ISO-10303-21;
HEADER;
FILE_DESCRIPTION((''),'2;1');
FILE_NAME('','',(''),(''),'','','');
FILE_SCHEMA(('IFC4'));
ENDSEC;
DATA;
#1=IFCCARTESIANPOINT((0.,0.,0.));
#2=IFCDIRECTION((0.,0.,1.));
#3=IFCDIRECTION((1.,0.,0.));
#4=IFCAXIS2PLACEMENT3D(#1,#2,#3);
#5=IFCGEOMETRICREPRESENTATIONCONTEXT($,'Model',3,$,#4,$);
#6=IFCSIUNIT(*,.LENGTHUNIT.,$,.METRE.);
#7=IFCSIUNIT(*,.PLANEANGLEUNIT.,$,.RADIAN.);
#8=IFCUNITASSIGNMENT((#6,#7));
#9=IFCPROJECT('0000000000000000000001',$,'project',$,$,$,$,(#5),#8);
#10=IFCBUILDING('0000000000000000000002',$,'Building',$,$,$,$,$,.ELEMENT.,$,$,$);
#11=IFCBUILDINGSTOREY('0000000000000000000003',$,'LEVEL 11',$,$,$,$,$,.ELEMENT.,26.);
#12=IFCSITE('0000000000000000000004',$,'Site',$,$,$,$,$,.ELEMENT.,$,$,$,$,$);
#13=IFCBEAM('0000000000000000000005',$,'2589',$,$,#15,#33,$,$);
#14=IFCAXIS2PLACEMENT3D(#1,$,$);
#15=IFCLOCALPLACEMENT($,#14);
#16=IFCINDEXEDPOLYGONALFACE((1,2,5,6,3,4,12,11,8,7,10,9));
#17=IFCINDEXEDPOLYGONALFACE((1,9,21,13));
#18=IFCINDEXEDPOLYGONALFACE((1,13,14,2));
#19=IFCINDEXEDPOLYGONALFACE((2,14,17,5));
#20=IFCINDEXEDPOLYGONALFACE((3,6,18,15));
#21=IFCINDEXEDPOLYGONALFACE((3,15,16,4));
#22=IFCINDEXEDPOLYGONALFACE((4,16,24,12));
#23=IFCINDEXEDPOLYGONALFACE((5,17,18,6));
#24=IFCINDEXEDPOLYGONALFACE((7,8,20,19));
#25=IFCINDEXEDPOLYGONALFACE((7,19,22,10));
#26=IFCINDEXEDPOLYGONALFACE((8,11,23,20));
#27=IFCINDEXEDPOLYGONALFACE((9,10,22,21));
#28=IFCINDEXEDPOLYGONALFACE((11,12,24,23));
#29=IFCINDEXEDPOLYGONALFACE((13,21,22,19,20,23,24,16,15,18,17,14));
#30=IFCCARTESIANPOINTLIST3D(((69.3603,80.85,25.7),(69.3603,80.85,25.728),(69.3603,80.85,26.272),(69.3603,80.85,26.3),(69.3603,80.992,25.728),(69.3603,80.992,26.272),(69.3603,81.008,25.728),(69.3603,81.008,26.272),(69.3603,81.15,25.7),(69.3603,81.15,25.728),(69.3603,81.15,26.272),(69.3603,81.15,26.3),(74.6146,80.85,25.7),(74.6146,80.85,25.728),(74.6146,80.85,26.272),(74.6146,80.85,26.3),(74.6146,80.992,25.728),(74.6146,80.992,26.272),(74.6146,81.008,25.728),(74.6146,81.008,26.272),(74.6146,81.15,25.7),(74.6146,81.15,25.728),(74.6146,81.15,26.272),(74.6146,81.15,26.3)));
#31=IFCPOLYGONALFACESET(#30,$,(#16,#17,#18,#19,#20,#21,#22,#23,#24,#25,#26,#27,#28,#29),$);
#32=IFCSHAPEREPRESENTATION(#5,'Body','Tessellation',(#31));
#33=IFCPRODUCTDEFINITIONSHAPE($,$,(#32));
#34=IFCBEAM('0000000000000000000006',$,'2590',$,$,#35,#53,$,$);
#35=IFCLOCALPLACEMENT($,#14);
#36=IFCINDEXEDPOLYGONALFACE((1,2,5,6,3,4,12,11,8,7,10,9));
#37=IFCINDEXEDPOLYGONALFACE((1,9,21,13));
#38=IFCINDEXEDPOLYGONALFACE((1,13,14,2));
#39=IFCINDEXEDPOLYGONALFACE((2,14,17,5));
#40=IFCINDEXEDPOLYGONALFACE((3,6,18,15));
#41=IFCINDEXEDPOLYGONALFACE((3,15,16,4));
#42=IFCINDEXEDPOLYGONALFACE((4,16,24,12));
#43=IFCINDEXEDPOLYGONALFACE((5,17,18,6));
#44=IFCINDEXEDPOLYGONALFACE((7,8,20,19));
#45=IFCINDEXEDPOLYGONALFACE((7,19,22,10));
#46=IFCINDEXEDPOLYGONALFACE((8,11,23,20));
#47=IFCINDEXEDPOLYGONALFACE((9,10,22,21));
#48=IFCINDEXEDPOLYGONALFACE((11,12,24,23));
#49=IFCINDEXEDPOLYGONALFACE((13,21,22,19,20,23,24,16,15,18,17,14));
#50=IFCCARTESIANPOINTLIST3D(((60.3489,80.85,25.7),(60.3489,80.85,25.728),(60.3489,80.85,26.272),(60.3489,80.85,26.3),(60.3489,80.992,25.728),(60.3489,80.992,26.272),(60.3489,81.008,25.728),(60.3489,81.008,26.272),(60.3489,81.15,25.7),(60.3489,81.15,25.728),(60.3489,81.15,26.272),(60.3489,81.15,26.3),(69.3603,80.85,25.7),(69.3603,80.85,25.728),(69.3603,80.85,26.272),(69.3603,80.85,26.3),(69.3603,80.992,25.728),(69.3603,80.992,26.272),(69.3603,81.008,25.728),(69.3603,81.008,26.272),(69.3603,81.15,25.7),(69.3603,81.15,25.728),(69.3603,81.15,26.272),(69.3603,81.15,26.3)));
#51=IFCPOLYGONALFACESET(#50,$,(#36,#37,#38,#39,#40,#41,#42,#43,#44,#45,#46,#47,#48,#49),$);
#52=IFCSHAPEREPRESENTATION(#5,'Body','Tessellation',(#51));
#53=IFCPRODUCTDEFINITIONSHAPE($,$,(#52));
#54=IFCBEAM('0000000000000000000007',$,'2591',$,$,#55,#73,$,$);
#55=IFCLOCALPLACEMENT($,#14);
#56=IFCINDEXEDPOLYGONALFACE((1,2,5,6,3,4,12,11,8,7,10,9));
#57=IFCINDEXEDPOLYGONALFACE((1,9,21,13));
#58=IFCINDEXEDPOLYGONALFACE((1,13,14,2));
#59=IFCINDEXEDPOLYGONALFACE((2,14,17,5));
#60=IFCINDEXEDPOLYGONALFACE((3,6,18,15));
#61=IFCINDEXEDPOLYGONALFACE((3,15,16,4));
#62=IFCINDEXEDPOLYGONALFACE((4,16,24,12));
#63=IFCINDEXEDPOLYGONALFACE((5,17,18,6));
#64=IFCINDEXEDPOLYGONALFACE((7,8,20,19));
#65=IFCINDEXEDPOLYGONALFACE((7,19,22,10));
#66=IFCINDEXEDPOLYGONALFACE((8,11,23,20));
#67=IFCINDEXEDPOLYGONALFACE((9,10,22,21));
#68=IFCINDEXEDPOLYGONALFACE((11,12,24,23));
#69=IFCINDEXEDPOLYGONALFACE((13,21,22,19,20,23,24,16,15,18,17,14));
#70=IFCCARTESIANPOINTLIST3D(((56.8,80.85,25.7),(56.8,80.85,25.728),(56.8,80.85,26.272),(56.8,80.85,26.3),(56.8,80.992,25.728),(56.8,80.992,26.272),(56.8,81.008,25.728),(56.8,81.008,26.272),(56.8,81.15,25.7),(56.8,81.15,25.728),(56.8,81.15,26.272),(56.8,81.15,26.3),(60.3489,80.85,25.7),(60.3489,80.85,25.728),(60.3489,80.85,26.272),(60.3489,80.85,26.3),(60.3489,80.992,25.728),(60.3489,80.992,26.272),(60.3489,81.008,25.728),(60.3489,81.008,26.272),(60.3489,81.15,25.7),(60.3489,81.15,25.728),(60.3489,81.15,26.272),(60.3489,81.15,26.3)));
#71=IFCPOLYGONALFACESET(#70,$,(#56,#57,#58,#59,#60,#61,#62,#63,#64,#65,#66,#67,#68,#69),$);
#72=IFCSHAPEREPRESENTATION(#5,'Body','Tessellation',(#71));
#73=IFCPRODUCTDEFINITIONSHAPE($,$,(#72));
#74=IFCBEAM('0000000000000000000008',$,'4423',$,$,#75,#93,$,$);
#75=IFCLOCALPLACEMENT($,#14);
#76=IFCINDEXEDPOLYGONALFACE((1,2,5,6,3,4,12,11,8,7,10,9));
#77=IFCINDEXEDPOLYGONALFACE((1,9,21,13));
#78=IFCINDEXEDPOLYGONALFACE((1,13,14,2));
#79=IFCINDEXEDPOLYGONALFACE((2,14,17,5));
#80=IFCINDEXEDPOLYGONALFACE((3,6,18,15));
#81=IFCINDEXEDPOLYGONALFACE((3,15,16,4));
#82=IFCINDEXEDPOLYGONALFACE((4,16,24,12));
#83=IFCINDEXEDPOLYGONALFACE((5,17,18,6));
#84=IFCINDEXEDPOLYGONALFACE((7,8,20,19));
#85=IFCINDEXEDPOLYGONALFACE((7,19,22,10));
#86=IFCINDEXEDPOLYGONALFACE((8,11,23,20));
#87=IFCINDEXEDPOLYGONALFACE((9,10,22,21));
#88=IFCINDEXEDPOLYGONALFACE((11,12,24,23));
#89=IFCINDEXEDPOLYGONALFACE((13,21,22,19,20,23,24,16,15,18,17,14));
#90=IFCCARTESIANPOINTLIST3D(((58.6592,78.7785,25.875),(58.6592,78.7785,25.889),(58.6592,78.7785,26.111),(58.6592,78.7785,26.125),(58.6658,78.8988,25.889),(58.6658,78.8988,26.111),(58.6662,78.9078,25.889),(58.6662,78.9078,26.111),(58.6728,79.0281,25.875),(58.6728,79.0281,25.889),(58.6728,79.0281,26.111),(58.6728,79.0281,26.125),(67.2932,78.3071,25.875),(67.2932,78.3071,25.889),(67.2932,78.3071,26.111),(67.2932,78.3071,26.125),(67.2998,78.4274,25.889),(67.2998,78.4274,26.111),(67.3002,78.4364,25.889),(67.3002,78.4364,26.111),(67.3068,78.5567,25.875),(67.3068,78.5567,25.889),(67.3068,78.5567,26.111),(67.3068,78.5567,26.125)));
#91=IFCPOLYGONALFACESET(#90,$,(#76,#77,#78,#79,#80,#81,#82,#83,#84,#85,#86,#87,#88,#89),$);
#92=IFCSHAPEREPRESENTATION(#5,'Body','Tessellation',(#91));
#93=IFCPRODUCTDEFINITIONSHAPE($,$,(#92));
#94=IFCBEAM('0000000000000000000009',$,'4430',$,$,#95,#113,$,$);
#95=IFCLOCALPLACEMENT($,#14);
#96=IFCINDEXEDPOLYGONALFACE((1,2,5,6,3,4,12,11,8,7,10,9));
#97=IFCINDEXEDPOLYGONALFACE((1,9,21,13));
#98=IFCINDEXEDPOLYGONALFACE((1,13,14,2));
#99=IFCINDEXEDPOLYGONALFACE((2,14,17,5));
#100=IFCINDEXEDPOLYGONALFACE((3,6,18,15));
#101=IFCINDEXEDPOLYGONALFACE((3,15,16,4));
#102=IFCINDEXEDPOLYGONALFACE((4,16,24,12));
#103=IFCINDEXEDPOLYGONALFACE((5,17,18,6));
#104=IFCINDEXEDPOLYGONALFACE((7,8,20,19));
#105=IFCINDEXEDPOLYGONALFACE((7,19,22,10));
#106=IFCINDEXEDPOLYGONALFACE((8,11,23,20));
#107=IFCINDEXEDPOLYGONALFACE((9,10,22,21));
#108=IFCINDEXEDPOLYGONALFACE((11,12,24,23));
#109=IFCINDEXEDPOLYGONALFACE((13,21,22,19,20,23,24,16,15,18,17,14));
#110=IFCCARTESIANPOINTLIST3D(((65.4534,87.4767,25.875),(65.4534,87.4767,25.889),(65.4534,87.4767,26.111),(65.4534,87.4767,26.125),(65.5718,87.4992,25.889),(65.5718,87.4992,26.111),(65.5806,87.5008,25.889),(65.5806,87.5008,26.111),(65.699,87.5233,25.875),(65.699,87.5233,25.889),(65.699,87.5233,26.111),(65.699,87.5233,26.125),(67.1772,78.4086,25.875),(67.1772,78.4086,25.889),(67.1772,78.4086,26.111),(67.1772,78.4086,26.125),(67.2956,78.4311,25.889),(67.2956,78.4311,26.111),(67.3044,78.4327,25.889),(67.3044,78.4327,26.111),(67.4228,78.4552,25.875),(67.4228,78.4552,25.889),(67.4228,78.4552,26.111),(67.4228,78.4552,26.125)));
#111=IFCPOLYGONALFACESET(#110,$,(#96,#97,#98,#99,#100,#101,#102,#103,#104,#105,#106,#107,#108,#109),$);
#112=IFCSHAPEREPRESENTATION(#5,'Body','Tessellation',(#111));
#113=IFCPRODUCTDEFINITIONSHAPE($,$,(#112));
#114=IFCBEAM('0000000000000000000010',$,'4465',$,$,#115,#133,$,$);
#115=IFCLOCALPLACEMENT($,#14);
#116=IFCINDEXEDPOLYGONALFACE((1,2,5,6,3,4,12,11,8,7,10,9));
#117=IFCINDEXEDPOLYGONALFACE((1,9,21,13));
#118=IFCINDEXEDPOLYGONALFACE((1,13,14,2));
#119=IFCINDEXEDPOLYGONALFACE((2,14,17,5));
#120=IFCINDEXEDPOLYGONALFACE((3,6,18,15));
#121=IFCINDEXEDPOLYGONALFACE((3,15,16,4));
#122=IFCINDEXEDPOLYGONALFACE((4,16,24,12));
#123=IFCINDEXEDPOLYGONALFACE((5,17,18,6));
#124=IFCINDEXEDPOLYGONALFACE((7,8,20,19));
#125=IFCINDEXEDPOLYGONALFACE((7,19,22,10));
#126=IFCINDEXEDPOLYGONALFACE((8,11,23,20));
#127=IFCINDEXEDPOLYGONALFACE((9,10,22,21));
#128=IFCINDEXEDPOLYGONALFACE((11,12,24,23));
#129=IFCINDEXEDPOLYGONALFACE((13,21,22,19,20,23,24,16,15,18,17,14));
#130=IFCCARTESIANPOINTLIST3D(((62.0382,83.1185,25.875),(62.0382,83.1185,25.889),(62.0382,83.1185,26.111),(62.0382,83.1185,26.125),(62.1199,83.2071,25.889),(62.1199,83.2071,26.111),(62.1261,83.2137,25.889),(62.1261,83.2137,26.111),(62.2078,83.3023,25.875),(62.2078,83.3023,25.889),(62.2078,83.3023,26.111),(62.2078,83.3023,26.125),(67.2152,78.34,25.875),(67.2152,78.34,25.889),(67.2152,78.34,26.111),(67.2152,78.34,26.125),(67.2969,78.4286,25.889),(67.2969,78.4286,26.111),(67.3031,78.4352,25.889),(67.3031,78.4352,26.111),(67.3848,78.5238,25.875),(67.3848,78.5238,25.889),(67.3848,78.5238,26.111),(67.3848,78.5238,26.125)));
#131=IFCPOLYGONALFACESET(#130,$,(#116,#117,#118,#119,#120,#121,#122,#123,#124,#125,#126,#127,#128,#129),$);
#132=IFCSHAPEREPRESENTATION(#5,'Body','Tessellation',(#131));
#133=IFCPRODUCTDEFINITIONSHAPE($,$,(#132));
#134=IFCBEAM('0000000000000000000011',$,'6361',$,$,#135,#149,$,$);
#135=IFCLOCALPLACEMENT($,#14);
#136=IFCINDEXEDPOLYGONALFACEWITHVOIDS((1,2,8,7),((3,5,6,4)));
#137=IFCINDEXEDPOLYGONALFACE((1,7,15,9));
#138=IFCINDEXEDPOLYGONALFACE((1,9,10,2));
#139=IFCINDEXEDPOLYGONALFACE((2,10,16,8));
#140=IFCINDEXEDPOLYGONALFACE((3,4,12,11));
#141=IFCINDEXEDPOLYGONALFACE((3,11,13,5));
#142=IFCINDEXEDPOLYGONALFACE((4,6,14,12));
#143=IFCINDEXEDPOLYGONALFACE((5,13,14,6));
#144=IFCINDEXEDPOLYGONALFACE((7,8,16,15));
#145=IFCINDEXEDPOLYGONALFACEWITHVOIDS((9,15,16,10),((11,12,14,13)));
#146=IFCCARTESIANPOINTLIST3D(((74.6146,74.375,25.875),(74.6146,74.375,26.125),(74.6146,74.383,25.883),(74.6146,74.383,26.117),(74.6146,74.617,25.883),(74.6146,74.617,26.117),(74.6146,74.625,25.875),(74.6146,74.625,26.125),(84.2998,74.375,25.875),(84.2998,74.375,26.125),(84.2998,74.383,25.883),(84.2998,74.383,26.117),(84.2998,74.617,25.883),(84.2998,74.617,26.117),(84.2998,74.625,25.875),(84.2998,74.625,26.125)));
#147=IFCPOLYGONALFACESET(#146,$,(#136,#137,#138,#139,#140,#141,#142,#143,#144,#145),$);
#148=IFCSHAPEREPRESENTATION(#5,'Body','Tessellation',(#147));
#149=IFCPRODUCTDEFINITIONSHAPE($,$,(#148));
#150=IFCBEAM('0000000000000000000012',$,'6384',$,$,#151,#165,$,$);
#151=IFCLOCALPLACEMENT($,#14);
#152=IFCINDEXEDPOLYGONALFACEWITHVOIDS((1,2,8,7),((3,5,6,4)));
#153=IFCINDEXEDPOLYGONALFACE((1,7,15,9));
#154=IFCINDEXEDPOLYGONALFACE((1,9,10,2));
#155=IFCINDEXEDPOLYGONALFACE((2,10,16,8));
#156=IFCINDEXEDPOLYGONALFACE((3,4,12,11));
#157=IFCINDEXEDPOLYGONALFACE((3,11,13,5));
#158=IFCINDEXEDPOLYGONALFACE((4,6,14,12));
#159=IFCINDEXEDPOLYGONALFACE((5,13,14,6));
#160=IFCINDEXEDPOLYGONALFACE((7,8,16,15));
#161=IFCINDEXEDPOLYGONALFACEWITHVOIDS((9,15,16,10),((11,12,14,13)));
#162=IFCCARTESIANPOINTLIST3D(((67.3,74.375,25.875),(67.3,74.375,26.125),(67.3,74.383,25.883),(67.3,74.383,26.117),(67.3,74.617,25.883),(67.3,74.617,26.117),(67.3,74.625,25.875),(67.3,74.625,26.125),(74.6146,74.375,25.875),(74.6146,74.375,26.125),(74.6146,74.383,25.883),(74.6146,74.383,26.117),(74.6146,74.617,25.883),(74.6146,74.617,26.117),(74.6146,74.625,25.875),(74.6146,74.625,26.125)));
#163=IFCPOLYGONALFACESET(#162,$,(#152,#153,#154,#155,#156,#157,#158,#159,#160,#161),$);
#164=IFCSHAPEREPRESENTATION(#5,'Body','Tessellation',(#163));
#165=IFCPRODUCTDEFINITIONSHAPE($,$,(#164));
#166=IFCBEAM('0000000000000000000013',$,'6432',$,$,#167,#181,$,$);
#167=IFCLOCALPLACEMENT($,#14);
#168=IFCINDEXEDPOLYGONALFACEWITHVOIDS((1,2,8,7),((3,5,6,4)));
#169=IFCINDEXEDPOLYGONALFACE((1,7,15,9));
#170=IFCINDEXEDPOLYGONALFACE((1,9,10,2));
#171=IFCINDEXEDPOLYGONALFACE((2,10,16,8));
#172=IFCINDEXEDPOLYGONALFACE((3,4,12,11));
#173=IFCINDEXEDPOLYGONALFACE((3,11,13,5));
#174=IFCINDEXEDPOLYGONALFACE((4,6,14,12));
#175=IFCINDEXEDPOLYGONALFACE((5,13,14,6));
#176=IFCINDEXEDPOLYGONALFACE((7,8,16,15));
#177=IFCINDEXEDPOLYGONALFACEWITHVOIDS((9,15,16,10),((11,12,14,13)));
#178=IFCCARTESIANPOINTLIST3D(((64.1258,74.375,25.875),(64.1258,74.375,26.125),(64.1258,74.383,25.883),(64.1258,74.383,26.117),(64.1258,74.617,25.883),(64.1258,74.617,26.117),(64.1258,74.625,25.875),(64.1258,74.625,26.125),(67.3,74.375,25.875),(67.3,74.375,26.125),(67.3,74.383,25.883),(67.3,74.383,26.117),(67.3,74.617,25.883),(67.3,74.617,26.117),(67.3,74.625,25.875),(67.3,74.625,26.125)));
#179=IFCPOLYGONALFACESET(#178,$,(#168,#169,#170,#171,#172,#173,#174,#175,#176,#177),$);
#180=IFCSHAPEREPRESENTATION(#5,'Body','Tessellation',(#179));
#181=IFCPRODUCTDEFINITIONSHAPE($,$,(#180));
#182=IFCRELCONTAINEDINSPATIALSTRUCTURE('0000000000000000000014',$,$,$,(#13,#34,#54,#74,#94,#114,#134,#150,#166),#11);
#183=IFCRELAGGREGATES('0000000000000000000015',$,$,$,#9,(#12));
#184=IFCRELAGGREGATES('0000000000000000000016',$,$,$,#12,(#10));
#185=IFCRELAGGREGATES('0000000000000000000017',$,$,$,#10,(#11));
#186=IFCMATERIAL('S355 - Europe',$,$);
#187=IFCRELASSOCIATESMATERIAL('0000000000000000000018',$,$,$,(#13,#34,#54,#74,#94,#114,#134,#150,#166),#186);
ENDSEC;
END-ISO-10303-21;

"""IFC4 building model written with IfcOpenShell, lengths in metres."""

from ifc_helpers import new_model, si_unit, frame, origin_with_axes, origin_2d_with_axis, place, context, project, spatial, hollow_rectangle, i_section, extrude, material, material_profile, profile_set, profile_usage, element, save


model = new_model("IFC4")

# Units and contexts
model_context = context("Model", 3, world=origin_with_axes())
ifc_project = project(units=[si_unit("LENGTHUNIT", "METRE"), si_unit("PLANEANGLEUNIT", "RADIAN")], contexts=[model_context])

# Site, building, storey
site = spatial("IfcSite", under=ifc_project, Name="Site", CompositionType="ELEMENT")
building = spatial("IfcBuilding", under=site, Name="Building", CompositionType="ELEMENT")
storey = spatial("IfcBuildingStorey", under=building, Name="LEVEL 11", CompositionType="ELEMENT", Elevation=26.0)

# Shared definitions
ifc_material = material(Name="S355 - Europe")

# Beams
ifc_material_profile_1 = material_profile(ifc_material, i_section(OverallWidth=0.3, OverallDepth=0.6, WebThickness=0.016, FlangeThickness=0.028, at=origin_2d_with_axis()))
ifc_profile_set_1 = profile_set([ifc_material_profile_1])
ifc_profile_usage_1 = profile_usage(ifc_profile_set_1, cardinal=10)
beam_1_placement = place(None, frame((69.3603, 81.0, 26.0), z_axis=(1.0, 0.0, 0.0), x_axis=(0.0, 1.0, 0.0)))
element("IfcBeam", 1, at=beam_1_placement, inside=storey, material=ifc_profile_usage_1, Name="2589", context=model_context, shape_type="SweptSolid", body=[
    extrude(i_section(OverallWidth=0.3, OverallDepth=0.6, WebThickness=0.016, FlangeThickness=0.028, at=origin_2d_with_axis()), origin_with_axes(), (0.0, 0.0, 1.0), 5.2543),
])
ifc_material_profile_2 = material_profile(ifc_material, i_section(OverallWidth=0.3, OverallDepth=0.6, WebThickness=0.016, FlangeThickness=0.028, at=origin_2d_with_axis()))
ifc_profile_set_2 = profile_set([ifc_material_profile_2])
ifc_profile_usage_2 = profile_usage(ifc_profile_set_2, cardinal=10)
beam_2_placement = place(None, frame((60.3489, 81.0, 26.0), z_axis=(1.0, 0.0, 0.0), x_axis=(0.0, 1.0, 0.0)))
element("IfcBeam", 2, at=beam_2_placement, inside=storey, material=ifc_profile_usage_2, Name="2590", context=model_context, shape_type="SweptSolid", body=[
    extrude(i_section(OverallWidth=0.3, OverallDepth=0.6, WebThickness=0.016, FlangeThickness=0.028, at=origin_2d_with_axis()), origin_with_axes(), (0.0, 0.0, 1.0), 9.0114),
])
ifc_material_profile_3 = material_profile(ifc_material, i_section(OverallWidth=0.3, OverallDepth=0.6, WebThickness=0.016, FlangeThickness=0.028, at=origin_2d_with_axis()))
ifc_profile_set_3 = profile_set([ifc_material_profile_3])
ifc_profile_usage_3 = profile_usage(ifc_profile_set_3, cardinal=10)
beam_3_placement = place(None, frame((56.8, 81.0, 26.0), z_axis=(1.0, 0.0, 0.0), x_axis=(0.0, 1.0, 0.0)))
element("IfcBeam", 3, at=beam_3_placement, inside=storey, material=ifc_profile_usage_3, Name="2591", context=model_context, shape_type="SweptSolid", body=[
    extrude(i_section(OverallWidth=0.3, OverallDepth=0.6, WebThickness=0.016, FlangeThickness=0.028, at=origin_2d_with_axis()), origin_with_axes(), (0.0, 0.0, 1.0), 3.5489),
])
ifc_material_profile_4 = material_profile(ifc_material, i_section(OverallWidth=0.25, OverallDepth=0.25, WebThickness=0.009, FlangeThickness=0.014, at=origin_2d_with_axis()))
ifc_profile_set_4 = profile_set([ifc_material_profile_4])
ifc_profile_usage_4 = profile_usage(ifc_profile_set_4, cardinal=10)
beam_4_placement = place(None, frame((58.666, 78.9033, 26.0), z_axis=(0.998513, -0.054517, 0.0), x_axis=(0.054517, 0.998513, 0.0)))
element("IfcBeam", 4, at=beam_4_placement, inside=storey, material=ifc_profile_usage_4, Name="4423", context=model_context, shape_type="SweptSolid", body=[
    extrude(i_section(OverallWidth=0.25, OverallDepth=0.25, WebThickness=0.009, FlangeThickness=0.014, at=origin_2d_with_axis()), origin_with_axes(), (0.0, 0.0, 1.0), 8.6469),
])
ifc_material_profile_5 = material_profile(ifc_material, i_section(OverallWidth=0.25, OverallDepth=0.25, WebThickness=0.009, FlangeThickness=0.014, at=origin_2d_with_axis()))
ifc_profile_set_5 = profile_set([ifc_material_profile_5])
ifc_profile_usage_5 = profile_usage(ifc_profile_set_5, cardinal=10)
beam_5_placement = place(None, frame((67.3, 78.4319, 26.0), z_axis=(-0.186751, 0.982407, 0.0), x_axis=(-0.982407, -0.186751, 0.0)))
element("IfcBeam", 5, at=beam_5_placement, inside=storey, material=ifc_profile_usage_5, Name="4430", context=model_context, shape_type="SweptSolid", body=[
    extrude(i_section(OverallWidth=0.25, OverallDepth=0.25, WebThickness=0.009, FlangeThickness=0.014, at=origin_2d_with_axis()), origin_with_axes(), (0.0, 0.0, 1.0), 9.2305),
])
ifc_material_profile_6 = material_profile(ifc_material, i_section(OverallWidth=0.25, OverallDepth=0.25, WebThickness=0.009, FlangeThickness=0.014, at=origin_2d_with_axis()))
ifc_profile_set_6 = profile_set([ifc_material_profile_6])
ifc_profile_usage_6 = profile_usage(ifc_profile_set_6, cardinal=10)
beam_6_placement = place(None, frame((67.3, 78.4319, 26.0), z_axis=(-0.734822, 0.678259, 0.0), x_axis=(-0.678259, -0.734822, 0.0)))
element("IfcBeam", 6, at=beam_6_placement, inside=storey, material=ifc_profile_usage_6, Name="4465", context=model_context, shape_type="SweptSolid", body=[
    extrude(i_section(OverallWidth=0.25, OverallDepth=0.25, WebThickness=0.009, FlangeThickness=0.014, at=origin_2d_with_axis()), origin_with_axes(), (0.0, 0.0, 1.0), 7.0452),
])
ifc_material_profile_7 = material_profile(ifc_material, hollow_rectangle(XDim=0.25, YDim=0.25, WallThickness=0.008, at=origin_2d_with_axis()))
ifc_profile_set_7 = profile_set([ifc_material_profile_7])
ifc_profile_usage_7 = profile_usage(ifc_profile_set_7, cardinal=10)
beam_7_placement = place(None, frame((74.6146, 74.5, 26.0), z_axis=(1.0, 0.0, 0.0), x_axis=(0.0, 1.0, 0.0)))
element("IfcBeam", 7, at=beam_7_placement, inside=storey, material=ifc_profile_usage_7, Name="6361", context=model_context, shape_type="SweptSolid", body=[
    extrude(hollow_rectangle(XDim=0.25, YDim=0.25, WallThickness=0.008, at=origin_2d_with_axis()), origin_with_axes(), (0.0, 0.0, 1.0), 9.6852),
])
ifc_material_profile_8 = material_profile(ifc_material, hollow_rectangle(XDim=0.25, YDim=0.25, WallThickness=0.008, at=origin_2d_with_axis()))
ifc_profile_set_8 = profile_set([ifc_material_profile_8])
ifc_profile_usage_8 = profile_usage(ifc_profile_set_8, cardinal=10)
beam_8_placement = place(None, frame((67.3, 74.5, 26.0), z_axis=(1.0, 0.0, 0.0), x_axis=(0.0, 1.0, 0.0)))
element("IfcBeam", 8, at=beam_8_placement, inside=storey, material=ifc_profile_usage_8, Name="6384", context=model_context, shape_type="SweptSolid", body=[
    extrude(hollow_rectangle(XDim=0.25, YDim=0.25, WallThickness=0.008, at=origin_2d_with_axis()), origin_with_axes(), (0.0, 0.0, 1.0), 7.3146),
])
ifc_material_profile_9 = material_profile(ifc_material, hollow_rectangle(XDim=0.25, YDim=0.25, WallThickness=0.008, at=origin_2d_with_axis()))
ifc_profile_set_9 = profile_set([ifc_material_profile_9])
ifc_profile_usage_9 = profile_usage(ifc_profile_set_9, cardinal=10)
beam_9_placement = place(None, frame((64.1258, 74.5, 26.0), z_axis=(1.0, 0.0, 0.0), x_axis=(0.0, 1.0, 0.0)))
element("IfcBeam", 9, at=beam_9_placement, inside=storey, material=ifc_profile_usage_9, Name="6432", context=model_context, shape_type="SweptSolid", body=[
    extrude(hollow_rectangle(XDim=0.25, YDim=0.25, WallThickness=0.008, at=origin_2d_with_axis()), origin_with_axes(), (0.0, 0.0, 1.0), 3.1742),
])

save(model, "model.ifc")
